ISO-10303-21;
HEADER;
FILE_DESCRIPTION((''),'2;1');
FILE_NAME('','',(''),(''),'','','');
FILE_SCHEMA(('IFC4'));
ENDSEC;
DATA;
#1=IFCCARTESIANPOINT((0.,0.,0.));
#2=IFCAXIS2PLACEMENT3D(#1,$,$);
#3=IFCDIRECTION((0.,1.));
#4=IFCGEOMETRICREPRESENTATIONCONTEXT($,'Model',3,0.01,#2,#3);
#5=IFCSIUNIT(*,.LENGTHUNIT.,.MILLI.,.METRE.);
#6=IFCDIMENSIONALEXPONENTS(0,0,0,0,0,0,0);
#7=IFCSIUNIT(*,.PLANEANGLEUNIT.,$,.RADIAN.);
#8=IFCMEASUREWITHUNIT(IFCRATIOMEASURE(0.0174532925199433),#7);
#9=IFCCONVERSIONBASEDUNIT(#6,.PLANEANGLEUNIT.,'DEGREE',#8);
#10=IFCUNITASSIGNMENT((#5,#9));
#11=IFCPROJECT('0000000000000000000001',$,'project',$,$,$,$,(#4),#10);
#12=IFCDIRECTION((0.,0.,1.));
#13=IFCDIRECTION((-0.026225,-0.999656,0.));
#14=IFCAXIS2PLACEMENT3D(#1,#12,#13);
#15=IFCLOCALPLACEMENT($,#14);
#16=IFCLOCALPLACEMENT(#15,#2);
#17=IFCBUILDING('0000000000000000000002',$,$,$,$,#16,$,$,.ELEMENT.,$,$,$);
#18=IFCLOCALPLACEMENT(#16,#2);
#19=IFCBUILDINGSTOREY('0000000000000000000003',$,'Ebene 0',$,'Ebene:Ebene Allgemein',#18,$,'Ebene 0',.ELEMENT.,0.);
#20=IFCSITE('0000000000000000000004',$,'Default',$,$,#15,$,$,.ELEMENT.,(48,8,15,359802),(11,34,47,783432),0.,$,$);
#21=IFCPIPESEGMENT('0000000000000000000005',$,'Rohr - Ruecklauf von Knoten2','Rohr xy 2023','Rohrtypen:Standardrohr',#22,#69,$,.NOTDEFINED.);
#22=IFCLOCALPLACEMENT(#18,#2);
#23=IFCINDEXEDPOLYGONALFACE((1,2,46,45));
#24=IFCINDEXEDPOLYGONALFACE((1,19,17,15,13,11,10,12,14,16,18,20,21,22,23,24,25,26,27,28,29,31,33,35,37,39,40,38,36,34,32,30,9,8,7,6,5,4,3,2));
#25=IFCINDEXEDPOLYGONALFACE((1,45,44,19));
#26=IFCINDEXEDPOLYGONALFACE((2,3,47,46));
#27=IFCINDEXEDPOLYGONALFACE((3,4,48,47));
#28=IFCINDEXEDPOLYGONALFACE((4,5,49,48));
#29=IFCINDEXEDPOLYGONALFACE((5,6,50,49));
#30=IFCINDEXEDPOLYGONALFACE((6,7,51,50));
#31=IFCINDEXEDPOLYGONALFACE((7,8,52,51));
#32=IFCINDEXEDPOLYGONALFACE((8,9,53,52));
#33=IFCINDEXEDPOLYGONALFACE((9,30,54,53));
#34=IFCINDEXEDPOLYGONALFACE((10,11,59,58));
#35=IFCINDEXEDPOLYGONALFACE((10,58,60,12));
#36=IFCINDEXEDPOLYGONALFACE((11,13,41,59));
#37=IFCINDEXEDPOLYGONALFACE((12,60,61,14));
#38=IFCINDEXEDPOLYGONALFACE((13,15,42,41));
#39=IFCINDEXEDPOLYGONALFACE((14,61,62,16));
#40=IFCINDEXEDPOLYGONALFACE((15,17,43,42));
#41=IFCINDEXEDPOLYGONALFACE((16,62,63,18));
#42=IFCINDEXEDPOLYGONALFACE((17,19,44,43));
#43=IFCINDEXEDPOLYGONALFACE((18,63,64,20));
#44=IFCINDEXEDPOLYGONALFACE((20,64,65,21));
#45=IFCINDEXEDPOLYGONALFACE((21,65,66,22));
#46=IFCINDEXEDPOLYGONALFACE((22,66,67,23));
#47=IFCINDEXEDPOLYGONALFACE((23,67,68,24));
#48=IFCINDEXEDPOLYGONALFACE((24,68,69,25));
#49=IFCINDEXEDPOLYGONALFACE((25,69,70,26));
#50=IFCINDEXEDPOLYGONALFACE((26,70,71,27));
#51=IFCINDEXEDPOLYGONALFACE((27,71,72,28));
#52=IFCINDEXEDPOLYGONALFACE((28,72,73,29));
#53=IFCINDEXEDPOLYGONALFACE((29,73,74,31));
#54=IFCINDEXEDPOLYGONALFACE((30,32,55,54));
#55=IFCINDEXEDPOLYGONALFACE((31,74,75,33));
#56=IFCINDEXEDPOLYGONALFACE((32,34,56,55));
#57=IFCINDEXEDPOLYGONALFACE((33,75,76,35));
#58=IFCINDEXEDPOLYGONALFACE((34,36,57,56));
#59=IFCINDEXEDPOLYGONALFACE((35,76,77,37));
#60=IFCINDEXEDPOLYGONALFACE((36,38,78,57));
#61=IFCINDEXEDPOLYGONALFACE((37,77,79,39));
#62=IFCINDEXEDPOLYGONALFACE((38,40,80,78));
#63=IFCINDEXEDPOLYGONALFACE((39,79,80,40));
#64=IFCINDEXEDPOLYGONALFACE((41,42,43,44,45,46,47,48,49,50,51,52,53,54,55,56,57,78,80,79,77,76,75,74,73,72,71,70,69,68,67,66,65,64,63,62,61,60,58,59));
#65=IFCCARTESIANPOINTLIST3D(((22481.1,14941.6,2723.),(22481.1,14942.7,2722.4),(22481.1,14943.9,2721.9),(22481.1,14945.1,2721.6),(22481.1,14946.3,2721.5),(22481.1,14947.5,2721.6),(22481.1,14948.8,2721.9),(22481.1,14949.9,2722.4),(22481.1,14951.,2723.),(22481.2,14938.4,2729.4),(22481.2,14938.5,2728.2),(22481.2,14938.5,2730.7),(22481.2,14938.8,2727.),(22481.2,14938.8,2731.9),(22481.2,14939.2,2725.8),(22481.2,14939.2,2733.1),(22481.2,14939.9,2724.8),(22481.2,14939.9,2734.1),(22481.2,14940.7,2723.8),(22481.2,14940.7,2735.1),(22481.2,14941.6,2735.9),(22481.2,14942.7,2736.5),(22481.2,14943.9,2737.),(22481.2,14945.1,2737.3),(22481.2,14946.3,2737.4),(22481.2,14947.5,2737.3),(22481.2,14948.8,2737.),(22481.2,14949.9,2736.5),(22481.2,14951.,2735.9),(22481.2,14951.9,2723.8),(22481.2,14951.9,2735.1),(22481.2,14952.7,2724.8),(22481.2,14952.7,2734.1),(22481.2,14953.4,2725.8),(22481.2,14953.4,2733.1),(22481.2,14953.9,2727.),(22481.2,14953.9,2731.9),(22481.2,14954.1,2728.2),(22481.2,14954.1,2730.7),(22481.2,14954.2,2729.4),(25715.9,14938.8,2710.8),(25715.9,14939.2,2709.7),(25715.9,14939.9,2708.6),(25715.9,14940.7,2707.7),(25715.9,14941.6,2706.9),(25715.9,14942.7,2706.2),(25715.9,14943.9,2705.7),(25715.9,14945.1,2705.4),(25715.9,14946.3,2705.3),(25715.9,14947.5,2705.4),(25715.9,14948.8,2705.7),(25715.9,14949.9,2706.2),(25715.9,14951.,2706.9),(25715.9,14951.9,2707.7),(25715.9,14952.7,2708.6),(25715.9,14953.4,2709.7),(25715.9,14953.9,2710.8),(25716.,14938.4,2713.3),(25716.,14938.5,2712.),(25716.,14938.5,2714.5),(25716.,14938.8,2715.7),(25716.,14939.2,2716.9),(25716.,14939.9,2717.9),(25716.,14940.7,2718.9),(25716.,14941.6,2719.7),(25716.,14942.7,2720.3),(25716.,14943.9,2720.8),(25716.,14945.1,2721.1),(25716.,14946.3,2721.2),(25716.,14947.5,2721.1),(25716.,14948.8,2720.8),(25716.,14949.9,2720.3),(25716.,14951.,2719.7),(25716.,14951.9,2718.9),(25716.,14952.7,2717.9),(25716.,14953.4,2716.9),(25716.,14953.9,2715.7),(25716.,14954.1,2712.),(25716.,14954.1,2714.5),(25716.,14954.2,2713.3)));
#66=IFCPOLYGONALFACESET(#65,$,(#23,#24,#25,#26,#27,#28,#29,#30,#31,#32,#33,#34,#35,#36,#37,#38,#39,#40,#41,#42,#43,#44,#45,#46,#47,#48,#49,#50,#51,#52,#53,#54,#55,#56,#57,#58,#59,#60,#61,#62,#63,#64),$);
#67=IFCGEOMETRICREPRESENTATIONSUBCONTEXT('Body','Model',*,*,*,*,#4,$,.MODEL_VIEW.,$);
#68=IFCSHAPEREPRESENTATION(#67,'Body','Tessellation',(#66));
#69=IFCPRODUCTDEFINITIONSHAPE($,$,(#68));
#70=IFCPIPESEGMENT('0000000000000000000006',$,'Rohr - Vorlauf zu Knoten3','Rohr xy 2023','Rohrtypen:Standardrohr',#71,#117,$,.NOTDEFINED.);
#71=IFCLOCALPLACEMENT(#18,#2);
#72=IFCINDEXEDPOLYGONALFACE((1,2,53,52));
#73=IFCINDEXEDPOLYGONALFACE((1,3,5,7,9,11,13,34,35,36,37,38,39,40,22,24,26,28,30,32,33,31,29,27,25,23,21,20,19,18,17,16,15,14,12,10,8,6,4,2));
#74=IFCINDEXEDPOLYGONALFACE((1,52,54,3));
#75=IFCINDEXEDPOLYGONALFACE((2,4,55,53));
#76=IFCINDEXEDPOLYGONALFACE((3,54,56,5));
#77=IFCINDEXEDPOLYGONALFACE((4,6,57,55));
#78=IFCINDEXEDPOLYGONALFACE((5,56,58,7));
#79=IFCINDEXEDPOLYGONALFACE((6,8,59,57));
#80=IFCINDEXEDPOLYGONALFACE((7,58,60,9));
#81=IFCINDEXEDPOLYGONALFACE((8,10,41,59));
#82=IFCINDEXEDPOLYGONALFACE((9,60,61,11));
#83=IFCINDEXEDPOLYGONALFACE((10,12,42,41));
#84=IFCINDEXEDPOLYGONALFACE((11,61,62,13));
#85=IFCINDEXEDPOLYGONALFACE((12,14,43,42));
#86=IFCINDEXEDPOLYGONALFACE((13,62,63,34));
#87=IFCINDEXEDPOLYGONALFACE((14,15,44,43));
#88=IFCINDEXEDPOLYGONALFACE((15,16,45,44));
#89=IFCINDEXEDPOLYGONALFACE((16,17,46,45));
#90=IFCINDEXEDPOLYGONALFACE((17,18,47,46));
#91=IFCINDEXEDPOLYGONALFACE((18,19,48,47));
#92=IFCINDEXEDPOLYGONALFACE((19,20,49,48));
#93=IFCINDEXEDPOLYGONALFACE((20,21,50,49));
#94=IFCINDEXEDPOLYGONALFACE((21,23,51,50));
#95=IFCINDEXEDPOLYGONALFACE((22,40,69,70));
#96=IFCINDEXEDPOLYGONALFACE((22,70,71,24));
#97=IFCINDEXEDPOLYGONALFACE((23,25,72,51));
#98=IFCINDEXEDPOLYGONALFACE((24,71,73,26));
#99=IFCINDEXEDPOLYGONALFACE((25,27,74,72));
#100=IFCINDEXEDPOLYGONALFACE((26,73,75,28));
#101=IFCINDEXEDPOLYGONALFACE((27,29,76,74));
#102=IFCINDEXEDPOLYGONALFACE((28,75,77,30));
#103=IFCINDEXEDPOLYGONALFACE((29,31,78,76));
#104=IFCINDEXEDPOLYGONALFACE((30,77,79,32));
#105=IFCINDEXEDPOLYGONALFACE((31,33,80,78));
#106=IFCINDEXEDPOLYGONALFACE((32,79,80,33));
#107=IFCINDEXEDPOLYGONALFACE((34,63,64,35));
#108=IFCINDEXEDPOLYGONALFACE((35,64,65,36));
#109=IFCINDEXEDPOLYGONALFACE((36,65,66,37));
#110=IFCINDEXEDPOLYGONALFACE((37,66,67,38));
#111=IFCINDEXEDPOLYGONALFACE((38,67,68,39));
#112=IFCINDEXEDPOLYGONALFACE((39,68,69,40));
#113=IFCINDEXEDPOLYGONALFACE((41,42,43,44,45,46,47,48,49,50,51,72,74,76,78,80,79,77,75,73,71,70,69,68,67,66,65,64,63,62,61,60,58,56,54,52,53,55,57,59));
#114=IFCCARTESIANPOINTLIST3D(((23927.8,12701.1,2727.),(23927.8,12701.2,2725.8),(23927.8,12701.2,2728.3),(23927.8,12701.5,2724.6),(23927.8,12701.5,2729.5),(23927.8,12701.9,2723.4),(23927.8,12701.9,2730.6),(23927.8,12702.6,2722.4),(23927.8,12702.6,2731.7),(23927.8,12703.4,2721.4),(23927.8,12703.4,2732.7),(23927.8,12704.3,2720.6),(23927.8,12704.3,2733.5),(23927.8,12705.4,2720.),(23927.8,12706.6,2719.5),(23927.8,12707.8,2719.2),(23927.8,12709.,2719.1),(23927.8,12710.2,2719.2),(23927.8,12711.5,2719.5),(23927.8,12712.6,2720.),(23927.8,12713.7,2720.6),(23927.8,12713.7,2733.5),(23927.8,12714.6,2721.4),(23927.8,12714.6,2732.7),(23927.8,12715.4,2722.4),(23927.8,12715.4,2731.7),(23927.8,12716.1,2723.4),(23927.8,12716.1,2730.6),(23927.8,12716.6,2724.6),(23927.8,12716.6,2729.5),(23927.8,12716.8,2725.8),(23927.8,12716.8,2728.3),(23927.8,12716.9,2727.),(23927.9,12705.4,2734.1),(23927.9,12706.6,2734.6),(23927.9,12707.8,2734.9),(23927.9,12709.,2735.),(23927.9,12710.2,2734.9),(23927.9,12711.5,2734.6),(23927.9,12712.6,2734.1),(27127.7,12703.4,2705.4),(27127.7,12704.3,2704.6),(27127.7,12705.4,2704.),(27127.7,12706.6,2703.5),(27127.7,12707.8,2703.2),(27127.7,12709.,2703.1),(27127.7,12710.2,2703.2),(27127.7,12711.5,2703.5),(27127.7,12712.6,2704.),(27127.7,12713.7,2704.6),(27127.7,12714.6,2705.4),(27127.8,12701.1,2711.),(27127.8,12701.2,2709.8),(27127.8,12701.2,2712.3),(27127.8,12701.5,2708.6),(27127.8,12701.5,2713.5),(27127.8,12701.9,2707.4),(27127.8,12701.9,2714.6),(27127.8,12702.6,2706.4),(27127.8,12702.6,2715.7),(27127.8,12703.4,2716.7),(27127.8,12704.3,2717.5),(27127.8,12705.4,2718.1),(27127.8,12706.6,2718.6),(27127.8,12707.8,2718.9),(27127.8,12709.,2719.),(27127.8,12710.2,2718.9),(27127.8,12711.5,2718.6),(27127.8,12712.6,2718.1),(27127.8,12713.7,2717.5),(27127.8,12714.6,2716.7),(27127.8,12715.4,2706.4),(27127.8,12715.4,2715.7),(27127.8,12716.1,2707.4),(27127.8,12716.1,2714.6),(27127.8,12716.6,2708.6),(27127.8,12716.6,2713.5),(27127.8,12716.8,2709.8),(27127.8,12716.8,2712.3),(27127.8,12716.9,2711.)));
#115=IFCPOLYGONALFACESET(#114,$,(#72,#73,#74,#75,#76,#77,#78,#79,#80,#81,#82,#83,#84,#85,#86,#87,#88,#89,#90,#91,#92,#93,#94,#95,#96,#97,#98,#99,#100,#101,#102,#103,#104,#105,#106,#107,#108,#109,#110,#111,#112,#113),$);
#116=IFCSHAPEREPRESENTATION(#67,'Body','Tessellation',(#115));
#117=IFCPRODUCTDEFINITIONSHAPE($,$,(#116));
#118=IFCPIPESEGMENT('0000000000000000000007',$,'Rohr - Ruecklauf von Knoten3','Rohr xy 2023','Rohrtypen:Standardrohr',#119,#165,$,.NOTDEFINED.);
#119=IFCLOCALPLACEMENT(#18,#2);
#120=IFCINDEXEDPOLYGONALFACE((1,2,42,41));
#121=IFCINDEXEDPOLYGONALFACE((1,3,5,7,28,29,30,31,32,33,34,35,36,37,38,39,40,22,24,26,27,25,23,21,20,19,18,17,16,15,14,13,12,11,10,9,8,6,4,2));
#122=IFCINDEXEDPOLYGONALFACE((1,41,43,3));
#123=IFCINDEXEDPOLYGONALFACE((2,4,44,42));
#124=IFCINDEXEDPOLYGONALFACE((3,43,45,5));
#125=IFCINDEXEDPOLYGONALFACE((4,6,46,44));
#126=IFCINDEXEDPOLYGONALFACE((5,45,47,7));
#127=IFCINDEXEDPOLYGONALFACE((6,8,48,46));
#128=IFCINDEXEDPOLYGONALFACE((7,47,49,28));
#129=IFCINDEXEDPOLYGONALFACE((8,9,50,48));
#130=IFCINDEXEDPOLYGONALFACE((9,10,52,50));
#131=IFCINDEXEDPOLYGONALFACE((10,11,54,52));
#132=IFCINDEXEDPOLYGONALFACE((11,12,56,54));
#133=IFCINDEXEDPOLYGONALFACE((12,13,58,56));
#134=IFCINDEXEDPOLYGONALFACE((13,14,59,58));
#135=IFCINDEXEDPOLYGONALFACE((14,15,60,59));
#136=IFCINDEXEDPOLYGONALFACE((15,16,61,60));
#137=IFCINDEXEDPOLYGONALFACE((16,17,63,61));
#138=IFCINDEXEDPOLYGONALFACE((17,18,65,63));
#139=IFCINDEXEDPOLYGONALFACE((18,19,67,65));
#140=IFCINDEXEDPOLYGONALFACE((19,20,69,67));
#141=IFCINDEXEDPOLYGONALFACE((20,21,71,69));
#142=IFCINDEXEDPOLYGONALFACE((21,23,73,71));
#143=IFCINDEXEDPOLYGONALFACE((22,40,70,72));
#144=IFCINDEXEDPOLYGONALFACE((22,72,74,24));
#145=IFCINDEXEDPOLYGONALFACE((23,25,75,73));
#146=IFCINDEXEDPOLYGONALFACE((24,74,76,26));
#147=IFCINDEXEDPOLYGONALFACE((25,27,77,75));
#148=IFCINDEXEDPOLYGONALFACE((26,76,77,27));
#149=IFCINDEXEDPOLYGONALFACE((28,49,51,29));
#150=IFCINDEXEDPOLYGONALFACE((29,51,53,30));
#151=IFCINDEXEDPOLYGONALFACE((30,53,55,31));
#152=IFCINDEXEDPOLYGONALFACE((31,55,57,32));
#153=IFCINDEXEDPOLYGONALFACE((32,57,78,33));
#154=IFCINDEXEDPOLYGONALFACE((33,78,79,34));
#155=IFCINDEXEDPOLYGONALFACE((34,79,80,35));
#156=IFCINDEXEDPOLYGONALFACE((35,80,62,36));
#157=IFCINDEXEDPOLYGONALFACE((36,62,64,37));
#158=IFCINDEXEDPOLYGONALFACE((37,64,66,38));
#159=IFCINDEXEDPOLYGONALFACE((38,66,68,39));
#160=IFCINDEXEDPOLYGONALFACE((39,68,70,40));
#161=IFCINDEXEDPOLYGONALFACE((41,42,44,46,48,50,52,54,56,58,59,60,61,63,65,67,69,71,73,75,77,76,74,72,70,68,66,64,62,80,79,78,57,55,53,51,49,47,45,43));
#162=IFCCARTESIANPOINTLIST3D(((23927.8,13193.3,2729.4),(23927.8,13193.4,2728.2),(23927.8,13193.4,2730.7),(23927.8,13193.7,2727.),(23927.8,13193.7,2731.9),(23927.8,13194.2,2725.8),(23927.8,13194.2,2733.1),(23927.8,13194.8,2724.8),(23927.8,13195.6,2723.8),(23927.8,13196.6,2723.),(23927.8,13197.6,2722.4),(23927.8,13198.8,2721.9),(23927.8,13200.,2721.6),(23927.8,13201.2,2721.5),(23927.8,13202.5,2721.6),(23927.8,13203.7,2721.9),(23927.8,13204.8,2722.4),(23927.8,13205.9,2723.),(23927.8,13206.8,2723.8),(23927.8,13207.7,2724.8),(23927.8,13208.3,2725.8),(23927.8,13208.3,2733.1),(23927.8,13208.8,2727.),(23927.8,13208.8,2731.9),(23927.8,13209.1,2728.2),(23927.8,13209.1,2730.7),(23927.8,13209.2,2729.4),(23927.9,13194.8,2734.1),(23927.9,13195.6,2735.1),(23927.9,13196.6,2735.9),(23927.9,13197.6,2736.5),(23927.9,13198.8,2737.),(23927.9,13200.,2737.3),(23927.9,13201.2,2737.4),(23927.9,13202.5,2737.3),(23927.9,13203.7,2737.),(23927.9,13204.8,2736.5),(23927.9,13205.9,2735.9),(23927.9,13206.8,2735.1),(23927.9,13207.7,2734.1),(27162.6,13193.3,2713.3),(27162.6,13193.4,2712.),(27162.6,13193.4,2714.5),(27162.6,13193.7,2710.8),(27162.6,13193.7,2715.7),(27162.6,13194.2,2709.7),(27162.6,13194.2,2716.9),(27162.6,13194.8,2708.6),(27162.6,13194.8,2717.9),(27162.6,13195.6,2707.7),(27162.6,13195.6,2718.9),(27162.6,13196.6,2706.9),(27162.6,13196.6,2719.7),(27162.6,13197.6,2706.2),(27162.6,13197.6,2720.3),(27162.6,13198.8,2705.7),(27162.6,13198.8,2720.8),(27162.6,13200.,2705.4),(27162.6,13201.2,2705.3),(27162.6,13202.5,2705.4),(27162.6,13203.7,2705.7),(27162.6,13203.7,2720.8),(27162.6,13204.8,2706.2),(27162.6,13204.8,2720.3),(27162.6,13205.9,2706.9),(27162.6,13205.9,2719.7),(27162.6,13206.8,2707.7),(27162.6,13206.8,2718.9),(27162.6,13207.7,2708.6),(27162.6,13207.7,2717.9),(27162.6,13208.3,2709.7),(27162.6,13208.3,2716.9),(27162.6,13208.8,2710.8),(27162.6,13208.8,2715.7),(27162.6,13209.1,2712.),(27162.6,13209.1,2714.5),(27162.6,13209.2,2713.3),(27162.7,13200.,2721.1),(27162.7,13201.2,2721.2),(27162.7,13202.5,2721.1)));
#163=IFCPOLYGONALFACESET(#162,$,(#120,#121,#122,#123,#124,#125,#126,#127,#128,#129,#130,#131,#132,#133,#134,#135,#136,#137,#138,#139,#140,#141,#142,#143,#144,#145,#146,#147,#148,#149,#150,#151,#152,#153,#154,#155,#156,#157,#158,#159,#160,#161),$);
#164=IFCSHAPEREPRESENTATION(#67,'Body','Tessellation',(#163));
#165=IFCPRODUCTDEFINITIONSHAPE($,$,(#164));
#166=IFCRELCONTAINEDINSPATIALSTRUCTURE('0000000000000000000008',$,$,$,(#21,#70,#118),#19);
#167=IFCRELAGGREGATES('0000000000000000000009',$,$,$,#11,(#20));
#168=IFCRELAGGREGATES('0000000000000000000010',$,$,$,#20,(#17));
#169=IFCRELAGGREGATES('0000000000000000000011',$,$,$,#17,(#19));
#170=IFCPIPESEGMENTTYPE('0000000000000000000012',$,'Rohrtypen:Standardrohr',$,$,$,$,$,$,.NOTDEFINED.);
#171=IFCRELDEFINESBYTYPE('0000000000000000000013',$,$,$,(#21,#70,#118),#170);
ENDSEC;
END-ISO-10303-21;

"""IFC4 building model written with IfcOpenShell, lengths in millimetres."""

from ifc_helpers import new_model, entity, si_unit, converted_unit, direction, frame, origin, place, context, subcontext, project, spatial, indexed_curve, outline, extrude, type_object, element, save


model = new_model("IFC4")

# Units and contexts
model_context = context("Model", 3, precision=0.01, world=origin(), true_north=direction((0.0, 1.0)))
body_context = subcontext(model_context, "Body", "Model", "MODEL_VIEW")
ifc_project = project(units=[si_unit("LENGTHUNIT", "METRE", prefix="MILLI"), converted_unit("PLANEANGLEUNIT", "DEGREE", entity("IfcRatioMeasure", 0.0174532925199433), si_unit("PLANEANGLEUNIT", "RADIAN"), dimensions=[0, 0, 0, 0, 0, 0, 0])], contexts=[model_context])

# Site, building, storey
site_placement = place(None, frame((0.0, 0.0, 0.0), z_axis=(0.0, 0.0, 1.0), x_axis=(-0.026225, -0.999656, 0.0)))
site = spatial("IfcSite", under=ifc_project, at=site_placement, Name="Default", CompositionType="ELEMENT", RefLatitude=(48, 8, 15, 359802), RefLongitude=(11, 34, 47, 783432), RefElevation=0.0)
building_placement = place(site_placement, origin())
building = spatial("IfcBuilding", under=site, at=building_placement, CompositionType="ELEMENT")
storey_placement = place(building_placement, origin())
storey = spatial("IfcBuildingStorey", under=building, at=storey_placement, Name="Ebene 0", ObjectType="Ebene:Ebene Allgemein", LongName="Ebene 0", CompositionType="ELEMENT", Elevation=0.0)

# Pipe segments
pipe_segment_type = type_object("IfcPipeSegmentType", Name="Rohrtypen:Standardrohr", PredefinedType="NOTDEFINED")
pipe_segment_1_placement = place(storey_placement, origin())
element("IfcPipeSegment", 1, at=pipe_segment_1_placement, inside=storey, type_object=pipe_segment_type, Name="Rohr - Ruecklauf von Knoten2", Description="Rohr xy 2023", ObjectType="Rohrtypen:Standardrohr", PredefinedType="NOTDEFINED", context=body_context, shape_type="SweptSolid", body=[
    extrude(outline(indexed_curve([(7.9, 0.0), (7.8, 1.2), (7.6, 2.5), (7.1, 3.6), (6.4, 4.7), (5.6, 5.6), (4.7, 6.4), (3.6, 7.1), (2.5, 7.6), (1.2, 7.8), (0.0, 7.9), (-1.2, 7.8), (-2.5, 7.6), (-3.6, 7.1), (-4.7, 6.4), (-5.6, 5.6), (-6.4, 4.7), (-7.1, 3.6), (-7.6, 2.5), (-7.8, 1.2), (-7.9, 0.0), (-7.8, -1.2), (-7.6, -2.5), (-7.1, -3.6), (-6.4, -4.7), (-5.6, -5.6), (-4.7, -6.4), (-3.6, -7.1), (-2.5, -7.6), (-1.2, -7.8), (0.0, -7.9), (1.2, -7.8), (2.5, -7.6), (3.6, -7.1), (4.7, -6.4), (5.6, -5.6), (6.4, -4.7), (7.1, -3.6), (7.6, -2.5), (7.8, -1.2), (7.9, 0.0)], self_intersect=False)), frame((25716.0, 14946.3, 2713.3), z_axis=(-0.999988, 0.0, 0.005), x_axis=(0.0, 1.0, 0.0)), (0.0, 0.0, 1.0), 3234.8),
])
pipe_segment_2_placement = place(storey_placement, origin())
element("IfcPipeSegment", 2, at=pipe_segment_2_placement, inside=storey, type_object=pipe_segment_type, Name="Rohr - Vorlauf zu Knoten3", Description="Rohr xy 2023", ObjectType="Rohrtypen:Standardrohr", PredefinedType="NOTDEFINED", context=body_context, shape_type="SweptSolid", body=[
    extrude(outline(indexed_curve([(7.9, 0.0), (7.8, 1.2), (7.6, 2.5), (7.1, 3.6), (6.4, 4.7), (5.6, 5.6), (4.7, 6.4), (3.6, 7.1), (2.5, 7.6), (1.2, 7.8), (0.0, 7.9), (-1.2, 7.8), (-2.5, 7.6), (-3.6, 7.1), (-4.7, 6.4), (-5.6, 5.6), (-6.4, 4.7), (-7.1, 3.6), (-7.6, 2.5), (-7.8, 1.2), (-7.9, 0.0), (-7.8, -1.2), (-7.6, -2.5), (-7.1, -3.6), (-6.4, -4.7), (-5.6, -5.6), (-4.7, -6.4), (-3.6, -7.1), (-2.5, -7.6), (-1.2, -7.8), (0.0, -7.9), (1.2, -7.8), (2.5, -7.6), (3.6, -7.1), (4.7, -6.4), (5.6, -5.6), (6.4, -4.7), (7.1, -3.6), (7.6, -2.5), (7.8, -1.2), (7.9, 0.0)], self_intersect=False)), frame((27127.8, 12709.0, 2711.0), z_axis=(-0.999988, 0.0, 0.005), x_axis=(0.0, 1.0, 0.0)), (0.0, 0.0, 1.0), 3200.0),
])
pipe_segment_3_placement = place(storey_placement, origin())
element("IfcPipeSegment", 3, at=pipe_segment_3_placement, inside=storey, type_object=pipe_segment_type, Name="Rohr - Ruecklauf von Knoten3", Description="Rohr xy 2023", ObjectType="Rohrtypen:Standardrohr", PredefinedType="NOTDEFINED", context=body_context, shape_type="SweptSolid", body=[
    extrude(outline(indexed_curve([(7.9, 0.0), (7.8, 1.2), (7.6, 2.5), (7.1, 3.6), (6.4, 4.7), (5.6, 5.6), (4.7, 6.4), (3.6, 7.1), (2.5, 7.6), (1.2, 7.8), (0.0, 7.9), (-1.2, 7.8), (-2.5, 7.6), (-3.6, 7.1), (-4.7, 6.4), (-5.6, 5.6), (-6.4, 4.7), (-7.1, 3.6), (-7.6, 2.5), (-7.8, 1.2), (-7.9, 0.0), (-7.8, -1.2), (-7.6, -2.5), (-7.1, -3.6), (-6.4, -4.7), (-5.6, -5.6), (-4.7, -6.4), (-3.6, -7.1), (-2.5, -7.6), (-1.2, -7.8), (0.0, -7.9), (1.2, -7.8), (2.5, -7.6), (3.6, -7.1), (4.7, -6.4), (5.6, -5.6), (6.4, -4.7), (7.1, -3.6), (7.6, -2.5), (7.8, -1.2), (7.9, 0.0)], self_intersect=False)), frame((27162.6, 13201.2, 2713.3), z_axis=(-0.999988, 0.0, 0.005), x_axis=(0.0, 1.0, 0.0)), (0.0, 0.0, 1.0), 3234.8),
])

save(model, "model.ifc")
